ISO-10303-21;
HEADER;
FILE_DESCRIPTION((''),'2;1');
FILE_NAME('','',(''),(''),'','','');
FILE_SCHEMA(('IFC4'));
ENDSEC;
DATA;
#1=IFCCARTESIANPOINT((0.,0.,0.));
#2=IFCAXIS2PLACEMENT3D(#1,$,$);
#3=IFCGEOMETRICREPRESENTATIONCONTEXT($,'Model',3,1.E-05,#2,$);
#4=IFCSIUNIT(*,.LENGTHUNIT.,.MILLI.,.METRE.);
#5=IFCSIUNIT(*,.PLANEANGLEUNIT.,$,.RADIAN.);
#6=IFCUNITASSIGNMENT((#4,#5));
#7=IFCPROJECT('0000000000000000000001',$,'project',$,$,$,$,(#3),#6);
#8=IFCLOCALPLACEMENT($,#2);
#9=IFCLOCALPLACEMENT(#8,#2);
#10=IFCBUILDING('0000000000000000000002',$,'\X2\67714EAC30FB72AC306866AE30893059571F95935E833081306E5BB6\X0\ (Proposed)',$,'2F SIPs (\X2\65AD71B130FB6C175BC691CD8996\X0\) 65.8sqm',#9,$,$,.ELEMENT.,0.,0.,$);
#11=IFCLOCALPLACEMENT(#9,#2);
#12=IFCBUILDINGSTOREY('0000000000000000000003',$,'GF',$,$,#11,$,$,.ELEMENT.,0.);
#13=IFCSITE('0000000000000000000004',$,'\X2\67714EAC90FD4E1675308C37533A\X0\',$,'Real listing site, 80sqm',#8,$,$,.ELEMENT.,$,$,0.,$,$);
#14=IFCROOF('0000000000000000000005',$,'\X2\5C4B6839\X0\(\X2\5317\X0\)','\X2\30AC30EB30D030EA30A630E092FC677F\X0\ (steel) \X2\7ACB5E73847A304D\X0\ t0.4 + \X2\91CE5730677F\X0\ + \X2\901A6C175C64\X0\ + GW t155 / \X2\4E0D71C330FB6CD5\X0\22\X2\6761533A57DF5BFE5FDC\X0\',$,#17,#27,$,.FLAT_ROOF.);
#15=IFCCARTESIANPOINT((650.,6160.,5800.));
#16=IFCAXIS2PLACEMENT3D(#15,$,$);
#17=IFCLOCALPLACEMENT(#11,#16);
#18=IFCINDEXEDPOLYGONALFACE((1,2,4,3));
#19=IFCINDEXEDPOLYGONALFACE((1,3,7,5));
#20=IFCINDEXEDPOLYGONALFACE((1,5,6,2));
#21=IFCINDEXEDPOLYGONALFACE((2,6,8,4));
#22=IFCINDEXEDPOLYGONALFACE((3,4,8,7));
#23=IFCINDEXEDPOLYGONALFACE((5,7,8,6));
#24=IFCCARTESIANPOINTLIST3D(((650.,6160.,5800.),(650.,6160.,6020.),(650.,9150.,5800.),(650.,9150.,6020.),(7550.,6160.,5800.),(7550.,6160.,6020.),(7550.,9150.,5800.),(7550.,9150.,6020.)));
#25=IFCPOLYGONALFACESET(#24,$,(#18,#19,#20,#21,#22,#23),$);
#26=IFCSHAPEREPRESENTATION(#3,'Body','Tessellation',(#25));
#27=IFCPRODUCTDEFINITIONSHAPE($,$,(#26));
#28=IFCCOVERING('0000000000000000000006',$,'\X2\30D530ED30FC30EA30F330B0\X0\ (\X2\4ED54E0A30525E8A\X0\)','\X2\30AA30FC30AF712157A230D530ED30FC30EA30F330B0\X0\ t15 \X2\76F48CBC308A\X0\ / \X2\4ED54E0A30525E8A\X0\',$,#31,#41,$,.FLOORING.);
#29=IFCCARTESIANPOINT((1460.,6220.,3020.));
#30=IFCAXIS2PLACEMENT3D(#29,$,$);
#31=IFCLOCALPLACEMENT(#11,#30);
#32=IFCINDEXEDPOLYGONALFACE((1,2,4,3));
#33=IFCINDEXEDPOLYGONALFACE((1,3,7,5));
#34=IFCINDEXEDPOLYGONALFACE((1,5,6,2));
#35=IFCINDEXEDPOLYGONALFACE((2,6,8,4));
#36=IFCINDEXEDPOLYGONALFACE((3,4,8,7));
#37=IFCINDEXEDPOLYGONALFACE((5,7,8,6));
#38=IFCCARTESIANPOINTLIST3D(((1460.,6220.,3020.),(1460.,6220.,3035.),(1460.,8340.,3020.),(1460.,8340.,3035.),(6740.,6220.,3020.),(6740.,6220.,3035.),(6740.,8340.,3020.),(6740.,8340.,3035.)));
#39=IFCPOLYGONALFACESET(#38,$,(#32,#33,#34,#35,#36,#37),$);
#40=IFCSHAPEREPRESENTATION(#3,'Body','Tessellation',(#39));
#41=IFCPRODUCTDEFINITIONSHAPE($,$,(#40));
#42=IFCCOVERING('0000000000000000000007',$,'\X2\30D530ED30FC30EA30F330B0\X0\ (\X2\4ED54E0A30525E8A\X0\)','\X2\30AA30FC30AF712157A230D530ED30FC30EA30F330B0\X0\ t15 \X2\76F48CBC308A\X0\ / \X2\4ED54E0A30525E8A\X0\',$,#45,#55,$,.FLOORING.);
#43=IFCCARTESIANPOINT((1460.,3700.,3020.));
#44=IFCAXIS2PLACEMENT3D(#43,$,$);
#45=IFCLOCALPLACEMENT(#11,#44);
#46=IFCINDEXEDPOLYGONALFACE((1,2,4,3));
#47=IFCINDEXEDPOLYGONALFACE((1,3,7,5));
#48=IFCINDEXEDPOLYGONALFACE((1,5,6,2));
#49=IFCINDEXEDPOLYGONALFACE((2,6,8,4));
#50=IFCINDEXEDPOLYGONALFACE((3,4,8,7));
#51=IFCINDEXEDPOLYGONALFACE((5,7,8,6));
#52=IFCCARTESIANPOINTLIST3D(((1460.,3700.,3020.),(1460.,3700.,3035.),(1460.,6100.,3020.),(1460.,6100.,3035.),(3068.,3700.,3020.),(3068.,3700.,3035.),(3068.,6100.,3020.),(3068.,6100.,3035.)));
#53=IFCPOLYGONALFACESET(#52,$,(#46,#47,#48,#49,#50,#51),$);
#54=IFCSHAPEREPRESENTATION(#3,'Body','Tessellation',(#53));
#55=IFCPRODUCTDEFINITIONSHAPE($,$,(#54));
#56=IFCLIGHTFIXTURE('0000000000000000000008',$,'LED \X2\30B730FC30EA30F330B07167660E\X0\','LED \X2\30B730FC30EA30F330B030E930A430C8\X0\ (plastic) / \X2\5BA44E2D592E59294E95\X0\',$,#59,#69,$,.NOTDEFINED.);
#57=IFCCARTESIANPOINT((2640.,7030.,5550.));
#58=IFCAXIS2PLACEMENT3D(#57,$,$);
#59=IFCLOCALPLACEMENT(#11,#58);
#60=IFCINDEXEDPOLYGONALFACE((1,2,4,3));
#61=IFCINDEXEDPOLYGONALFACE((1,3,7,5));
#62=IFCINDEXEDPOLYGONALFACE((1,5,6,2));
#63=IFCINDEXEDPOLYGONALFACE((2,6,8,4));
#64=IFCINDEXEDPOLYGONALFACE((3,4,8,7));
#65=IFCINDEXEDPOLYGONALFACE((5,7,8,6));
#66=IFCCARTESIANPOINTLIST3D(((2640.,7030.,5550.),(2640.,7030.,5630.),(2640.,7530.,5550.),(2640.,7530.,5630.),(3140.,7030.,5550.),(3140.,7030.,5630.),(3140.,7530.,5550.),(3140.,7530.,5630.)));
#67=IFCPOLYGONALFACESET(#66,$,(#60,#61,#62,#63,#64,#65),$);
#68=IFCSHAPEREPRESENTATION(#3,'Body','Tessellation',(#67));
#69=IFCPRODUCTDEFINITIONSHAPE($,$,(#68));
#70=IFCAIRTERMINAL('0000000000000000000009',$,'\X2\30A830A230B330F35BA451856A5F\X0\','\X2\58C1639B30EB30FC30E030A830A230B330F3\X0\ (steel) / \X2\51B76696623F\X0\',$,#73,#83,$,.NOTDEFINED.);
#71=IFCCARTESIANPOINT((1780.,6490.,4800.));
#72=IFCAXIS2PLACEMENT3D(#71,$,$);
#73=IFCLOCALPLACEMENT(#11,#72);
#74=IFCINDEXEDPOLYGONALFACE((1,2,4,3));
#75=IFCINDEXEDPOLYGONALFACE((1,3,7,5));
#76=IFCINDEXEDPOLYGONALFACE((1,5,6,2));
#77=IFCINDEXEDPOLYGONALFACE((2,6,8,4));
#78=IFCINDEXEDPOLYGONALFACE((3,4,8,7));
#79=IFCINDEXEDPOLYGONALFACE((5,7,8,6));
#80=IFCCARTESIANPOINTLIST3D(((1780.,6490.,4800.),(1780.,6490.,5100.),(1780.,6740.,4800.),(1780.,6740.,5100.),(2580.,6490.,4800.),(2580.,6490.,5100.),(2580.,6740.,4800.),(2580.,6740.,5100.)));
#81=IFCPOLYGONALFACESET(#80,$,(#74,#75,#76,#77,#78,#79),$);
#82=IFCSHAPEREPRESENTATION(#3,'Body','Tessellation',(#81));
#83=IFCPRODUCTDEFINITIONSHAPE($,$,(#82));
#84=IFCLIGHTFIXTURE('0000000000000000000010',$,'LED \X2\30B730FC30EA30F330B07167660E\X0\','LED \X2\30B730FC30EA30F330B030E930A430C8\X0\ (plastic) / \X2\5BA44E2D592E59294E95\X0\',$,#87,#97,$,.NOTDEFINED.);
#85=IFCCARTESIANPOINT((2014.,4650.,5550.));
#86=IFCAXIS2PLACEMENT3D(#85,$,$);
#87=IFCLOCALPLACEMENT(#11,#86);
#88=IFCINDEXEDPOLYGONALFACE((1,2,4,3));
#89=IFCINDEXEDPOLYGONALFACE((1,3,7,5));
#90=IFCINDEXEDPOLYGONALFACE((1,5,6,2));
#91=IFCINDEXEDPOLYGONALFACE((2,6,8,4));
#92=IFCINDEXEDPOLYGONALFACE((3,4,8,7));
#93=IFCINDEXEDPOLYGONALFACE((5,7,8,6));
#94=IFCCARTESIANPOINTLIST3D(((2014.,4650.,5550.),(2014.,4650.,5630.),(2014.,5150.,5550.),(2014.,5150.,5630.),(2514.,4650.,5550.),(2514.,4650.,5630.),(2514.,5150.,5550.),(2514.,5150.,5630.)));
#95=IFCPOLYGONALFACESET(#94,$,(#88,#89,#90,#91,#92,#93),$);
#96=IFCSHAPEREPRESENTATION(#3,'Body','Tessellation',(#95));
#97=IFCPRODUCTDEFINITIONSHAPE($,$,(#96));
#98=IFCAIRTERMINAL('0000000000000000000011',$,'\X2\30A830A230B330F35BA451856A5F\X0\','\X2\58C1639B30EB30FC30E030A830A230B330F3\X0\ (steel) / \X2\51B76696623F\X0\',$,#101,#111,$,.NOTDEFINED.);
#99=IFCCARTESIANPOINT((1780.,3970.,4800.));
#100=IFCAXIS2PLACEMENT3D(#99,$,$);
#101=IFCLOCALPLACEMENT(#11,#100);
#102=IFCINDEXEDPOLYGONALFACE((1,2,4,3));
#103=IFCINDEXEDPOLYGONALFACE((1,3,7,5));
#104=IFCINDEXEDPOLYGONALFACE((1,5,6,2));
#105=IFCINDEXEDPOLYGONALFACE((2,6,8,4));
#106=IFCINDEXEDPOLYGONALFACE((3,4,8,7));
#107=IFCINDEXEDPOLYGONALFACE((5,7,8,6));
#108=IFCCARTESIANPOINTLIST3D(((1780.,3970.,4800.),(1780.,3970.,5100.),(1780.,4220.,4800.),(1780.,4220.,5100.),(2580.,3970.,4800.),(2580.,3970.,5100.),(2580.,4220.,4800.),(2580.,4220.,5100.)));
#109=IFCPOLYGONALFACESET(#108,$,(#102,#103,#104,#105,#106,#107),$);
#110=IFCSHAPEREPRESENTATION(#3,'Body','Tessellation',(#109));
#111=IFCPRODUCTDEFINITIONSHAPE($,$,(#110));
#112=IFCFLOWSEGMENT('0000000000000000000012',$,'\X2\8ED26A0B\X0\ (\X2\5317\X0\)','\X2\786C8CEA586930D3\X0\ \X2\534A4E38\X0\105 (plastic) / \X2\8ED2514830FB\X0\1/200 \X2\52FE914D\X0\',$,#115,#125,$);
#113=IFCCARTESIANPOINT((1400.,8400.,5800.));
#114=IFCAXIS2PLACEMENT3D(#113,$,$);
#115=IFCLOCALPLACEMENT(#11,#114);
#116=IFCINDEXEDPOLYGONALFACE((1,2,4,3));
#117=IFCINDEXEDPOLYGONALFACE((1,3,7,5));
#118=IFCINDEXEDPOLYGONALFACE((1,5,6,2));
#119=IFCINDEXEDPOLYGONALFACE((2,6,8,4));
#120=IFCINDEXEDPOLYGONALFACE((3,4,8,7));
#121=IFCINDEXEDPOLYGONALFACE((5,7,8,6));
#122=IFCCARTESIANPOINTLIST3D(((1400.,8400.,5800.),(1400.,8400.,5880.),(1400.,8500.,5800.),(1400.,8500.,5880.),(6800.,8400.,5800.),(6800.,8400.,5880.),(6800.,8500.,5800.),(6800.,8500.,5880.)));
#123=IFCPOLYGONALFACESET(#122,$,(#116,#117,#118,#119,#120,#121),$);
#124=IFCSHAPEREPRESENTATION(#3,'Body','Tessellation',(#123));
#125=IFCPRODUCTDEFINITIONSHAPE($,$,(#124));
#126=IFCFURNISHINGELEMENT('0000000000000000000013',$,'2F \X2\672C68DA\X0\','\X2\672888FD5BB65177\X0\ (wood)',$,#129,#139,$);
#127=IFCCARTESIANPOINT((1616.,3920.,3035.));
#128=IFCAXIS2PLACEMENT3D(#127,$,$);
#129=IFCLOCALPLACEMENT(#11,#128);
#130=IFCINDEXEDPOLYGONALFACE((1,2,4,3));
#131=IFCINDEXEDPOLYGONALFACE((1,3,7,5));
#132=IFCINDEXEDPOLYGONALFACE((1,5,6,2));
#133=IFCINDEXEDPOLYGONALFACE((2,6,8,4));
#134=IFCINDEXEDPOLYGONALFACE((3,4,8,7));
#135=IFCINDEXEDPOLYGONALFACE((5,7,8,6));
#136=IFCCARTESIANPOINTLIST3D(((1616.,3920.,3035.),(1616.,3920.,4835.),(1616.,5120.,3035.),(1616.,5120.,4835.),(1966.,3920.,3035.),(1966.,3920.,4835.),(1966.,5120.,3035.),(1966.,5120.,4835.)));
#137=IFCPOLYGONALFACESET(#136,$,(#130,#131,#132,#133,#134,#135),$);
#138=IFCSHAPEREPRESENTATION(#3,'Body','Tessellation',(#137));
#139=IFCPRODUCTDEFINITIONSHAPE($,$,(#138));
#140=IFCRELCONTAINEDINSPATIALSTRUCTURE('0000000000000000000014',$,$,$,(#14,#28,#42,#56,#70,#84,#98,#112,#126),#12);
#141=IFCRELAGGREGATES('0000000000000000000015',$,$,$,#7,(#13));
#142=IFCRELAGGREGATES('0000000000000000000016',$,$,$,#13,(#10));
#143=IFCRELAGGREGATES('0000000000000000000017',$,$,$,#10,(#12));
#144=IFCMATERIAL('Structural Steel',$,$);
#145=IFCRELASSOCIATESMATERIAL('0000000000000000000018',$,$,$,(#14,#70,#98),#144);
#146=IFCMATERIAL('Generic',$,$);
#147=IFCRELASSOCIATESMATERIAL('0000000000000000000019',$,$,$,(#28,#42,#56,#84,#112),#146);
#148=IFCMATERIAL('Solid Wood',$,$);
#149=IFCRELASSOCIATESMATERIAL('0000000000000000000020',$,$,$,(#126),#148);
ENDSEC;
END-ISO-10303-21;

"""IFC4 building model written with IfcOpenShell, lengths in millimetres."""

from ifc_helpers import new_model, si_unit, frame, frame_2d, origin, place, context, project, spatial, rectangle, extrude, material, element, save


model = new_model("IFC4")

# Units and contexts
model_context = context("Model", 3, precision=1e-05, world=origin())
ifc_project = project(units=[si_unit("LENGTHUNIT", "METRE", prefix="MILLI"), si_unit("PLANEANGLEUNIT", "RADIAN")], contexts=[model_context])

# Site, building, storey
site_placement = place(None, origin())
site = spatial("IfcSite", under=ifc_project, at=site_placement, Name="東京都世田谷区", ObjectType="Real listing site, 80sqm", CompositionType="ELEMENT", RefElevation=0.0)
building_placement = place(site_placement, origin())
building = spatial("IfcBuilding", under=site, at=building_placement, Name="東京・犬と暮らす土間広めの家 (Proposed)", ObjectType="2F SIPs (断熱・気密重視) 65.8sqm", CompositionType="ELEMENT", ElevationOfRefHeight=0.0, ElevationOfTerrain=0.0)
storey_placement = place(building_placement, origin())
storey = spatial("IfcBuildingStorey", under=building, at=storey_placement, Name="GF", CompositionType="ELEMENT", Elevation=0.0)

# Shared definitions
ifc_material_1 = material(Name="Solid Wood")

# Roof
ifc_material_2 = material(Name="Structural Steel")
for number, where, name in (
    (1, (650.0, 6160.0, 5800.0), "屋根(北)"),
):
    element("IfcRoof", number, at=place(storey_placement, frame(where)), inside=storey, material=ifc_material_2, Name=name, Description="ガルバリウム鋼板 (steel) 立平葺き t0.4 + 野地板 + 通気層 + GW t155 / 不燃・法22条区域対応", PredefinedType="FLAT_ROOF", context=model_context, shape_type="SweptSolid", body=[
        extrude(rectangle(XDim=6900.0, YDim=2990.0, at=frame_2d((3450.0, 1495.0))), frame((650.0, 6160.0, 5800.0)), (0.0, 0.0, 1.0), 220.0),
    ])

# Coverings
ifc_material_3 = material(Name="Generic")
covering_1_placement = place(storey_placement, frame((1460.0, 6220.0, 3020.0)))
element("IfcCovering", 2, at=covering_1_placement, inside=storey, material=ifc_material_3, Name="フローリング (仕上げ床)", Description="オーク無垢フローリング t15 直貼り / 仕上げ床", PredefinedType="FLOORING", context=model_context, shape_type="SweptSolid", body=[
    extrude(rectangle(XDim=5280.0, YDim=2120.0, at=frame_2d((2640.0, 1060.0))), frame((1460.0, 6220.0, 3020.0)), (0.0, 0.0, 1.0), 15.0),
])
covering_2_placement = place(storey_placement, frame((1460.0, 3700.0, 3020.0)))
element("IfcCovering", 3, at=covering_2_placement, inside=storey, material=ifc_material_3, Name="フローリング (仕上げ床)", Description="オーク無垢フローリング t15 直貼り / 仕上げ床", PredefinedType="FLOORING", context=model_context, shape_type="SweptSolid", body=[
    extrude(rectangle(XDim=1608.0, YDim=2400.0, at=frame_2d((804.0, 1200.0))), frame((1460.0, 3700.0, 3020.0)), (0.0, 0.0, 1.0), 15.0),
])

# Light fixture
light_fixture_1_placement = place(storey_placement, frame((2640.0, 7030.0, 5550.0)))
element("IfcLightFixture", 4, at=light_fixture_1_placement, inside=storey, material=ifc_material_3, Name="LED シーリング照明", Description="LED シーリングライト (plastic) / 室中央天井", PredefinedType="NOTDEFINED", context=model_context, shape_type="SweptSolid", body=[
    extrude(rectangle(XDim=500.0, YDim=500.0, at=frame_2d((250.0, 250.0))), frame((2640.0, 7030.0, 5550.0)), (0.0, 0.0, 1.0), 80.0),
])

# Air terminal
air_terminal_1_placement = place(storey_placement, frame((1780.0, 6490.0, 4800.0)))
element("IfcAirTerminal", 5, at=air_terminal_1_placement, inside=storey, material=ifc_material_2, Name="エアコン室内機", Description="壁掛ルームエアコン (steel) / 冷暖房", PredefinedType="NOTDEFINED", context=model_context, shape_type="SweptSolid", body=[
    extrude(rectangle(XDim=800.0, YDim=250.0, at=frame_2d((400.0, 125.0))), frame((1780.0, 6490.0, 4800.0)), (0.0, 0.0, 1.0), 300.0),
])

# Light fixture
light_fixture_2_placement = place(storey_placement, frame((2014.0, 4650.0, 5550.0)))
element("IfcLightFixture", 6, at=light_fixture_2_placement, inside=storey, material=ifc_material_3, Name="LED シーリング照明", Description="LED シーリングライト (plastic) / 室中央天井", PredefinedType="NOTDEFINED", context=model_context, shape_type="SweptSolid", body=[
    extrude(rectangle(XDim=500.0, YDim=500.0, at=frame_2d((250.0, 250.0))), frame((2014.0, 4650.0, 5550.0)), (0.0, 0.0, 1.0), 80.0),
])

# Air terminal
air_terminal_2_placement = place(storey_placement, frame((1780.0, 3970.0, 4800.0)))
element("IfcAirTerminal", 7, at=air_terminal_2_placement, inside=storey, material=ifc_material_2, Name="エアコン室内機", Description="壁掛ルームエアコン (steel) / 冷暖房", PredefinedType="NOTDEFINED", context=model_context, shape_type="SweptSolid", body=[
    extrude(rectangle(XDim=800.0, YDim=250.0, at=frame_2d((400.0, 125.0))), frame((1780.0, 3970.0, 4800.0)), (0.0, 0.0, 1.0), 300.0),
])

# Flow segment
flow_segment_placement = place(storey_placement, frame((1400.0, 8400.0, 5800.0)))
element("IfcFlowSegment", 8, at=flow_segment_placement, inside=storey, material=ifc_material_3, Name="軒樋 (北)", Description="硬質塩ビ 半丸105 (plastic) / 軒先・1/200 勾配", context=model_context, shape_type="SweptSolid", body=[
    extrude(rectangle(XDim=5400.0, YDim=100.0, at=frame_2d((2700.0, 50.0))), frame((1400.0, 8400.0, 5800.0)), (0.0, 0.0, 1.0), 80.0),
])

# Furnishing element
furnishing_placement = place(storey_placement, frame((1616.0, 3920.0, 3035.0)))
element("IfcFurnishingElement", 9, at=furnishing_placement, inside=storey, material=ifc_material_1, Name="2F 本棚", Description="木製家具 (wood)", context=model_context, shape_type="SweptSolid", body=[
    extrude(rectangle(XDim=350.0, YDim=1200.0, at=frame_2d((175.0, 600.0))), frame((1616.0, 3920.0, 3035.0)), (0.0, 0.0, 1.0), 1800.0),
])

save(model, "model.ifc")
